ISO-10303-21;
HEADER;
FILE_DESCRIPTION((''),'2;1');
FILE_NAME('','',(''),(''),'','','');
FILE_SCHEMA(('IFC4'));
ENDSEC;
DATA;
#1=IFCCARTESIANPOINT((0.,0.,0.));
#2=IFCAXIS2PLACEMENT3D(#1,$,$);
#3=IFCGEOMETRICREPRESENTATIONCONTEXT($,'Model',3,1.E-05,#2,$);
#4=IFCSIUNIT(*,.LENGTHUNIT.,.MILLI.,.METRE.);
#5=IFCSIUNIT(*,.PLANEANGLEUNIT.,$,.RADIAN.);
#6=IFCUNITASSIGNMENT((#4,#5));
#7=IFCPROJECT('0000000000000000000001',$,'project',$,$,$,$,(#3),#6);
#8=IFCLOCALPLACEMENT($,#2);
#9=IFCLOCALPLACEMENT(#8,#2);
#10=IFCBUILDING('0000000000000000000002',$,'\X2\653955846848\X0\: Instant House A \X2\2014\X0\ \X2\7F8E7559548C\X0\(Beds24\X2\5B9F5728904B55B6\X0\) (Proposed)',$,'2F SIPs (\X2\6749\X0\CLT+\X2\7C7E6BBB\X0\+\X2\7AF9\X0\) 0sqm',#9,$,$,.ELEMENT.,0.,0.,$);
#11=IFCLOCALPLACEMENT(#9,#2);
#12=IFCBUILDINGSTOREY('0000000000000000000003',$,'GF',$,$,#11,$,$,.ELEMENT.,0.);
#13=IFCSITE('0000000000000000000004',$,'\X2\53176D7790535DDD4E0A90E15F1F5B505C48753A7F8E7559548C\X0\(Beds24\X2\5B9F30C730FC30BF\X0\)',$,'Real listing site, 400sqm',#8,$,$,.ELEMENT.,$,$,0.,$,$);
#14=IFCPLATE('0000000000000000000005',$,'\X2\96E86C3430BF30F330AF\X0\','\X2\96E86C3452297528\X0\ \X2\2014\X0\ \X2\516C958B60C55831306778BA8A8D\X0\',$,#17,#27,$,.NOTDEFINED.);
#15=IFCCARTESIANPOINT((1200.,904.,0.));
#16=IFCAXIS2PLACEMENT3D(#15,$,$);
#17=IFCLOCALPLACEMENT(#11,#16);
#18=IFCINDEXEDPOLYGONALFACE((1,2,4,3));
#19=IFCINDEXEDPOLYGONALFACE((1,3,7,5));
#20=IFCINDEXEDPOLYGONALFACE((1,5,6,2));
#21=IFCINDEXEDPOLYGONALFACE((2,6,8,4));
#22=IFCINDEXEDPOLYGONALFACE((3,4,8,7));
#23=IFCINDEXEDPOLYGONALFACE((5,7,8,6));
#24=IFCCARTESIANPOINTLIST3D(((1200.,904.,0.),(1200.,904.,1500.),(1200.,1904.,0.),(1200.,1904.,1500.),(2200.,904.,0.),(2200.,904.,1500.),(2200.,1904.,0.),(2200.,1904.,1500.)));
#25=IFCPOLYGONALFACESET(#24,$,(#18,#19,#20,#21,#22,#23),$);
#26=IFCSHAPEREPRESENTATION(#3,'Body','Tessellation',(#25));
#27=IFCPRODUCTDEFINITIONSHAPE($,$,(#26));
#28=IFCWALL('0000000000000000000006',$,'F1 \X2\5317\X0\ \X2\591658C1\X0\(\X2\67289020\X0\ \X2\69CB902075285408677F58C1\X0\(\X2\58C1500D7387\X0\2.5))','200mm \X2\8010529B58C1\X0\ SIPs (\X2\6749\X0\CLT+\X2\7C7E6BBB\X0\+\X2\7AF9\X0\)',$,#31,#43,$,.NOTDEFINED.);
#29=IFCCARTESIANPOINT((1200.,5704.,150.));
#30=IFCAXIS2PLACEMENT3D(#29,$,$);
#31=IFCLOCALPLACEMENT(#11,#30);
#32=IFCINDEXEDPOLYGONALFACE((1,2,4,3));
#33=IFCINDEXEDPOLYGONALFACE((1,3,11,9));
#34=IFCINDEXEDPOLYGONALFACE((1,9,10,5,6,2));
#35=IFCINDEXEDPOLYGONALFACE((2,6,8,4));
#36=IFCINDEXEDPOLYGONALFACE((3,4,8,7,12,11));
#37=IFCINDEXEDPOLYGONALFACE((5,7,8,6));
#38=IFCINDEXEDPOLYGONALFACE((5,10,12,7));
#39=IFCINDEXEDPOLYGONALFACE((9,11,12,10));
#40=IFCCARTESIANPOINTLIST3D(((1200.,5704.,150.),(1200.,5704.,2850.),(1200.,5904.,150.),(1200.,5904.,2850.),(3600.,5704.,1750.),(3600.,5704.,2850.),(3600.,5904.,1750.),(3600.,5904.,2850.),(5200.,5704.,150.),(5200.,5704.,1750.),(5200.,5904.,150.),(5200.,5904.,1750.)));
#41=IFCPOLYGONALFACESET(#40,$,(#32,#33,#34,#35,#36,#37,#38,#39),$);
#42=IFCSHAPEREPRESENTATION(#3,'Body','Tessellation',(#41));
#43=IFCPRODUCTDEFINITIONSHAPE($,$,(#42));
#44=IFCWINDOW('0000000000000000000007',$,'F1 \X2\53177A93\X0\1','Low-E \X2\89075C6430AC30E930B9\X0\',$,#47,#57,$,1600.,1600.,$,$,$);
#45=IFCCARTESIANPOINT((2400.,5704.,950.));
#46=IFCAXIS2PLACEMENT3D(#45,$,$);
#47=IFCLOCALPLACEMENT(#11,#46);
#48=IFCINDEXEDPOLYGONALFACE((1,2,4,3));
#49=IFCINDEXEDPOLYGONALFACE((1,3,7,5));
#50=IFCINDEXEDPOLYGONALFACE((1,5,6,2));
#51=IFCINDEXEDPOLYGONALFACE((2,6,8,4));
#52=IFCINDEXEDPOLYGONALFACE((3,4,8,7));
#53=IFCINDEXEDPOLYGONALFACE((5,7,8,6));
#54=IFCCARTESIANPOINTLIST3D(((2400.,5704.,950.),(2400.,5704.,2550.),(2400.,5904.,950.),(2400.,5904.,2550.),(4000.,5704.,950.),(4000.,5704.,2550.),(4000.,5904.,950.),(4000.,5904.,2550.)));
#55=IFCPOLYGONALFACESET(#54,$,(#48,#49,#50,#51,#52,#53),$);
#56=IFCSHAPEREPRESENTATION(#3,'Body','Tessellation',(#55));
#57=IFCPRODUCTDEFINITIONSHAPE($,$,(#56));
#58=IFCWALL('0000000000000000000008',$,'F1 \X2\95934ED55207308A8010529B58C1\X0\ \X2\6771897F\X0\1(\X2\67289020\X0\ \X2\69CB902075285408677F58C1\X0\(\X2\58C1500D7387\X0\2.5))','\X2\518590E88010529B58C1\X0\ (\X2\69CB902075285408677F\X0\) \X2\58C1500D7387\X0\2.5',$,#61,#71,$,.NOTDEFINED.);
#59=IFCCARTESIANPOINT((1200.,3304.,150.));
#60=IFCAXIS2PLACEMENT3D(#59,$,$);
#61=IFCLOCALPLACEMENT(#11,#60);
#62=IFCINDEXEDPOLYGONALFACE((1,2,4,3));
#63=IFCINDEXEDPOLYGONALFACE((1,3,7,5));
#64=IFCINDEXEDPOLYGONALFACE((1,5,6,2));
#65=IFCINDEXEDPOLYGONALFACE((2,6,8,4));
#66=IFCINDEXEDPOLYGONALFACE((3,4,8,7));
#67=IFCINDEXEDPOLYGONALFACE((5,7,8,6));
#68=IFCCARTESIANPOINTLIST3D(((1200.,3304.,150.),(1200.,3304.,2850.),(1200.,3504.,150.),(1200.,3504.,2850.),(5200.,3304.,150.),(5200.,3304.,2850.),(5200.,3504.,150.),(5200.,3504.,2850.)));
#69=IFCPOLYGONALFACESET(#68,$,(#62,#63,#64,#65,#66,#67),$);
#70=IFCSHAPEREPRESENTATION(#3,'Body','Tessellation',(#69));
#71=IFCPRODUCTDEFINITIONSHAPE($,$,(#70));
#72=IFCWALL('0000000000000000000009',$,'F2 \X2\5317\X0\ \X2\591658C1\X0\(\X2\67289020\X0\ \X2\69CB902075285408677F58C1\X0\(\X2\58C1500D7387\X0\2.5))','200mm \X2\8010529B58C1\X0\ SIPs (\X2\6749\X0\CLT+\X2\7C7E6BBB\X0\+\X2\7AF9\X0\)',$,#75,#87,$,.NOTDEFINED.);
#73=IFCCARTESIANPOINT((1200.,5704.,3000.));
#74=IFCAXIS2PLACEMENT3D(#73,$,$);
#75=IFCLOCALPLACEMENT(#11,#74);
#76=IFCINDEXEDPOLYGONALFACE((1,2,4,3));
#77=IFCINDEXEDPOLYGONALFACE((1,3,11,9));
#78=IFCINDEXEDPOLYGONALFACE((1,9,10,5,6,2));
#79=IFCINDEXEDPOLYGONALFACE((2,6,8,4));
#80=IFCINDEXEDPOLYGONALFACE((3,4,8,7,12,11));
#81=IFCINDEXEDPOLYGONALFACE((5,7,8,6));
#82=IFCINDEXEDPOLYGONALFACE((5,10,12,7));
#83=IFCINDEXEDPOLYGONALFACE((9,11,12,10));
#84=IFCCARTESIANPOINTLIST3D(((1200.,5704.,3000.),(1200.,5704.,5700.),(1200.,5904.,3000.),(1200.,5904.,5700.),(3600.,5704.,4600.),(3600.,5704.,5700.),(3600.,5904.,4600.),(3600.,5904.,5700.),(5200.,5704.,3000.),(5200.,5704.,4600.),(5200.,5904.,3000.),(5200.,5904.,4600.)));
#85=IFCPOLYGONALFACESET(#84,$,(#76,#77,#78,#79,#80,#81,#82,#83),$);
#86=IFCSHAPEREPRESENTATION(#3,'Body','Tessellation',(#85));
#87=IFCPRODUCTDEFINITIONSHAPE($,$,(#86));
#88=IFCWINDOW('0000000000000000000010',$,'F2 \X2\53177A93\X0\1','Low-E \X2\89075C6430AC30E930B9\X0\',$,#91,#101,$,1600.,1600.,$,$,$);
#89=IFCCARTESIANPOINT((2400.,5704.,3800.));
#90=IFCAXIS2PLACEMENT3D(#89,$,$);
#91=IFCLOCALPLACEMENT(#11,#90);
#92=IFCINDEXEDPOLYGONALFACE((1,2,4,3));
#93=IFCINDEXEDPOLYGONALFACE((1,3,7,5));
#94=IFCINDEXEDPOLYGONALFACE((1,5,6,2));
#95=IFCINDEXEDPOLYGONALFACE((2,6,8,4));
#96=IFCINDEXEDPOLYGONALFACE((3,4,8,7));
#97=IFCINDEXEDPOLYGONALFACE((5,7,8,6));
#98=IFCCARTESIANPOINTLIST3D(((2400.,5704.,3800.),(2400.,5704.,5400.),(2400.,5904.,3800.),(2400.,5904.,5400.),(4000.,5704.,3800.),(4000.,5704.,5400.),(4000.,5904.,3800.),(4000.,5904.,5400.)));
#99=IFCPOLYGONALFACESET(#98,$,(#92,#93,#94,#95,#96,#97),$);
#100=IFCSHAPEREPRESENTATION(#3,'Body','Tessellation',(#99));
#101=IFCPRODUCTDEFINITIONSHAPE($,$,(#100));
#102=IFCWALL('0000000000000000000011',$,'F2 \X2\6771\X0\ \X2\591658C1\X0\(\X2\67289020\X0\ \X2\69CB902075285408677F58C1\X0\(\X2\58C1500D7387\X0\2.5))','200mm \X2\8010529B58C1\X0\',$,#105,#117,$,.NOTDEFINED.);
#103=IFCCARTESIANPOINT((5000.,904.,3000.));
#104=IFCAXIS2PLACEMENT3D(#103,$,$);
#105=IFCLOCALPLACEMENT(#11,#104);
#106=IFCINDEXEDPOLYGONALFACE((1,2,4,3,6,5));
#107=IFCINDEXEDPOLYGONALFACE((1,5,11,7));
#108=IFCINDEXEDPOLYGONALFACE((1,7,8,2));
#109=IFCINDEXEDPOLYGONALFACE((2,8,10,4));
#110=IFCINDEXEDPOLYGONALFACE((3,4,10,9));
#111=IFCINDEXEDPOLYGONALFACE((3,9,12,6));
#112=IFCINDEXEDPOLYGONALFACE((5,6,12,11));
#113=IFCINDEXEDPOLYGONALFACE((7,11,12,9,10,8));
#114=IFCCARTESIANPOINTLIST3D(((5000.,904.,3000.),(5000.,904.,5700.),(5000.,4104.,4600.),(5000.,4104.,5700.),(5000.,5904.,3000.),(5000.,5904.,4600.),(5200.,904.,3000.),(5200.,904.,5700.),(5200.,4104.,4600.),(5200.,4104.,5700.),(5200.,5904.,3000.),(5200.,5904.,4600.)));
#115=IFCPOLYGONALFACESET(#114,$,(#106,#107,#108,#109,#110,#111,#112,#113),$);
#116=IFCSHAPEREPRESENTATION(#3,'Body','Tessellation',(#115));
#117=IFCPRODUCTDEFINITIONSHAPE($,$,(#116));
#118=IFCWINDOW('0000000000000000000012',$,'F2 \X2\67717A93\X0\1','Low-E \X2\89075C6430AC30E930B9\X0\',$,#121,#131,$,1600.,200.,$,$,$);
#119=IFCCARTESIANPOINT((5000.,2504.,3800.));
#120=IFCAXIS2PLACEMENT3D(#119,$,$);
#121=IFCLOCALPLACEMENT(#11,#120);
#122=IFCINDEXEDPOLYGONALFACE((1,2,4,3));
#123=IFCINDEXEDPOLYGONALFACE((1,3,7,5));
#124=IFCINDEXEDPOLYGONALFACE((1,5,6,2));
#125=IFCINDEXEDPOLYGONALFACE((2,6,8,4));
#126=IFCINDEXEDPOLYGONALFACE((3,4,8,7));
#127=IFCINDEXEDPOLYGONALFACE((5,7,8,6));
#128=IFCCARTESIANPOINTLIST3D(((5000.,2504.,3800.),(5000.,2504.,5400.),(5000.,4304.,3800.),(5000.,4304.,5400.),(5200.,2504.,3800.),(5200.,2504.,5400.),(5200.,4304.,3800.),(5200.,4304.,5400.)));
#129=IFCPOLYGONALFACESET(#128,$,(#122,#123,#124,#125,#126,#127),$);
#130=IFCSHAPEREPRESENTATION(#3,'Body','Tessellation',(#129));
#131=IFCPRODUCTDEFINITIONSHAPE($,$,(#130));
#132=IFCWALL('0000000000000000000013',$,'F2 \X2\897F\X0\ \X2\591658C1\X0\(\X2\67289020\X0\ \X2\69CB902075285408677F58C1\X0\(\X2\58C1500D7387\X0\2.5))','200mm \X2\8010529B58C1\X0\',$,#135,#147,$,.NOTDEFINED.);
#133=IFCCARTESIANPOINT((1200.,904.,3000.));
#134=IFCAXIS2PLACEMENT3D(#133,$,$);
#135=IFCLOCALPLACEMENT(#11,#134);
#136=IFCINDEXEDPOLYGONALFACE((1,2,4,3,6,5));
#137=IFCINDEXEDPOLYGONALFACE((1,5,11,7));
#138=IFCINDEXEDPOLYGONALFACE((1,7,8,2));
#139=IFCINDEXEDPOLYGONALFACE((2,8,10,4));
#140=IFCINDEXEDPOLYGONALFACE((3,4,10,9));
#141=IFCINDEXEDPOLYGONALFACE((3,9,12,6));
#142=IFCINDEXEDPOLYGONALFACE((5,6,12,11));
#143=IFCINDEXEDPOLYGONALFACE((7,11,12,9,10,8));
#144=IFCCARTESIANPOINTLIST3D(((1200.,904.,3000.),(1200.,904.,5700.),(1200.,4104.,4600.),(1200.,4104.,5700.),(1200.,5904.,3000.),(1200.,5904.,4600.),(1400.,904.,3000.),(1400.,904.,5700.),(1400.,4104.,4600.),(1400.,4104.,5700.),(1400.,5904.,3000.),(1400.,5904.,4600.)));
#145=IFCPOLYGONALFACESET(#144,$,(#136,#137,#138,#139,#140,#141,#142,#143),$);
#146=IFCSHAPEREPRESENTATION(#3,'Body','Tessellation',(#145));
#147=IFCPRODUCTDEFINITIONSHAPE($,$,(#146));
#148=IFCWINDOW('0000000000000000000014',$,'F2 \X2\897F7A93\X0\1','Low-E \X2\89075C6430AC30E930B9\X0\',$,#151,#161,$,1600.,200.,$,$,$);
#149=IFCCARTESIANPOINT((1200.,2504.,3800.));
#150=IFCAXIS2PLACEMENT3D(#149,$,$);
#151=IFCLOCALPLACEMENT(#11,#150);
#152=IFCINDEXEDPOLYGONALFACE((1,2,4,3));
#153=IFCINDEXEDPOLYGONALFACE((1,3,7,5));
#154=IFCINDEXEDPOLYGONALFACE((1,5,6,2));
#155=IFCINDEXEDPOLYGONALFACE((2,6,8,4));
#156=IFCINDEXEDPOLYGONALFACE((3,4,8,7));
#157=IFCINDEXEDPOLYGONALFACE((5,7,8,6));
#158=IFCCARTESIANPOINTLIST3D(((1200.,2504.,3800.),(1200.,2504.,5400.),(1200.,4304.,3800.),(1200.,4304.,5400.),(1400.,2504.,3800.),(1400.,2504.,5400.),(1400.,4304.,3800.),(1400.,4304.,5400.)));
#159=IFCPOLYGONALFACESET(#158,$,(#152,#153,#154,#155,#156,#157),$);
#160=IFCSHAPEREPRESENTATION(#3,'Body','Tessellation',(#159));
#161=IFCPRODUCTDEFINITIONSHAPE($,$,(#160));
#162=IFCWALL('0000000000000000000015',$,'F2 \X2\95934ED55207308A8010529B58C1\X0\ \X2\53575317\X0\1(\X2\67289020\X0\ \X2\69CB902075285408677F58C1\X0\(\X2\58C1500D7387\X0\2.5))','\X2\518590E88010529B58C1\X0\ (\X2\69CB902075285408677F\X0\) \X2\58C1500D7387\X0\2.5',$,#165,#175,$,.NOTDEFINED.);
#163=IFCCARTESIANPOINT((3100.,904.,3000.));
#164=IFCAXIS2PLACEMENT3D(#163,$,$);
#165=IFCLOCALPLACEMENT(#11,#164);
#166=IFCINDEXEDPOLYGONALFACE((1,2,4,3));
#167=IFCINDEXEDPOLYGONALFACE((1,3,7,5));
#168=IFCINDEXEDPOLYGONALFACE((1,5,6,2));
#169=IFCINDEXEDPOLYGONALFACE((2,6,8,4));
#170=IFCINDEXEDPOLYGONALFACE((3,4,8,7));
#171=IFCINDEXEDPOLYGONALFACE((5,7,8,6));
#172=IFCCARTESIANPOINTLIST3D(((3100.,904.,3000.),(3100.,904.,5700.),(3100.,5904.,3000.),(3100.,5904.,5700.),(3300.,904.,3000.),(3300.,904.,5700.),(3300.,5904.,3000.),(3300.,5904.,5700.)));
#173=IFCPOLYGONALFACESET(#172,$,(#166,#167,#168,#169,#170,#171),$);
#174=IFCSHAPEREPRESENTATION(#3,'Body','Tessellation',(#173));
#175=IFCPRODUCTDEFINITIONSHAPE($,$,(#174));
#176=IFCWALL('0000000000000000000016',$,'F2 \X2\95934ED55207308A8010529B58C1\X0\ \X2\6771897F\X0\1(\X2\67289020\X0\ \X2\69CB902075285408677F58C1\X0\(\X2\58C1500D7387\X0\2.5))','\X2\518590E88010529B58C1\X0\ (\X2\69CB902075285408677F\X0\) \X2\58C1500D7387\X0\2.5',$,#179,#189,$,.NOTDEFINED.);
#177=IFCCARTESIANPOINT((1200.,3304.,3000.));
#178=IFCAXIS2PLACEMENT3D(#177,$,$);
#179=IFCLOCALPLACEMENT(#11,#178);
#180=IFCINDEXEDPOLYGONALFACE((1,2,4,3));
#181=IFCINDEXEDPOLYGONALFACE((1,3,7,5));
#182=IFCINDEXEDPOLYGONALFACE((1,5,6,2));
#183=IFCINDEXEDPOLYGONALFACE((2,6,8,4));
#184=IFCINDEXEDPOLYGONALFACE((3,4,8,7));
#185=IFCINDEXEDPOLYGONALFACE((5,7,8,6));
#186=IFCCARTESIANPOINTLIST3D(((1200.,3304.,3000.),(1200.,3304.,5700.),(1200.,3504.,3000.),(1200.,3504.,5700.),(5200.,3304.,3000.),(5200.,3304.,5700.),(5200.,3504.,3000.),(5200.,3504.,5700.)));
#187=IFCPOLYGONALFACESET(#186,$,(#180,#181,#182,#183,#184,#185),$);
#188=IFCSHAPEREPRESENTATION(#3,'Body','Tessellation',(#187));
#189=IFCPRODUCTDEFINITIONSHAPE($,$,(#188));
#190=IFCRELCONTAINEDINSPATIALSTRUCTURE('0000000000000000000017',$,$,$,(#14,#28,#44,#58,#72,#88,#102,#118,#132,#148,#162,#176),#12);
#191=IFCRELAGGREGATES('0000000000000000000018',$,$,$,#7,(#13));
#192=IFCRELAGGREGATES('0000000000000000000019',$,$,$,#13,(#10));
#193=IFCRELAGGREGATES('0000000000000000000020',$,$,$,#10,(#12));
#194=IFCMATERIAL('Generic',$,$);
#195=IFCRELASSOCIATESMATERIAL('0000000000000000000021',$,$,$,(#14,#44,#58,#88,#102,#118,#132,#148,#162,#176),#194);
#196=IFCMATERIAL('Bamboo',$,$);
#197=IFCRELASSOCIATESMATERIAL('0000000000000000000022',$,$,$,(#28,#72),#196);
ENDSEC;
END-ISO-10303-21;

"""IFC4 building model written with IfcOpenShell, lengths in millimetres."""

from ifc_helpers import new_model, si_unit, frame, frame_2d, origin, place, context, project, spatial, rectangle, extrude, material, element, fill, save


model = new_model("IFC4")

# Units and contexts
model_context = context("Model", 3, precision=1e-05, world=origin())
ifc_project = project(units=[si_unit("LENGTHUNIT", "METRE", prefix="MILLI"), si_unit("PLANEANGLEUNIT", "RADIAN")], contexts=[model_context])

# Site, building, storey
site_placement = place(None, origin())
site = spatial("IfcSite", under=ifc_project, at=site_placement, Name="北海道川上郡弟子屈町美留和(Beds24実データ)", ObjectType="Real listing site, 400sqm", CompositionType="ELEMENT", RefElevation=0.0)
building_placement = place(site_placement, origin())
building = spatial("IfcBuilding", under=site, at=building_placement, Name="改善案: Instant House A — 美留和(Beds24実在運営) (Proposed)", ObjectType="2F SIPs (杉CLT+籾殻+竹) 0sqm", CompositionType="ELEMENT", ElevationOfRefHeight=0.0, ElevationOfTerrain=0.0)
storey_placement = place(building_placement, origin())
storey = spatial("IfcBuildingStorey", under=building, at=storey_placement, Name="GF", CompositionType="ELEMENT", Elevation=0.0)

# Plate
ifc_material_1 = material(Name="Generic")
plate_placement = place(storey_placement, frame((1200.0, 904.0, 0.0)))
element("IfcPlate", 1, at=plate_placement, inside=storey, material=ifc_material_1, Name="雨水タンク", Description="雨水利用 — 公開情報で確認", PredefinedType="NOTDEFINED", context=model_context, shape_type="SweptSolid", body=[
    extrude(rectangle(XDim=1000.0, YDim=1000.0, at=frame_2d((500.0, 500.0))), frame((1200.0, 904.0, 0.0)), (0.0, 0.0, 1.0), 1500.0),
])

# Wall, opening, window
ifc_material_2 = material(Name="Bamboo")
wall_1_placement = place(storey_placement, frame((1200.0, 5704.0, 150.0)))
wall_1 = element("IfcWall", 2, at=wall_1_placement, inside=storey, material=ifc_material_2, Name="F1 北 外壁(木造 構造用合板壁(壁倍率2.5))", Description="200mm 耐力壁 SIPs (杉CLT+籾殻+竹)", PredefinedType="NOTDEFINED", context=model_context, shape_type="SweptSolid", body=[
    extrude(rectangle(XDim=4000.0, YDim=200.0, at=frame_2d((2000.0, 100.0))), frame((1200.0, 5704.0, 150.0)), (0.0, 0.0, 1.0), 2700.0),
])
opening_1_placement = place(storey_placement, frame((2400.0, 5704.0, 950.0)))
opening_1 = element("IfcOpeningElement", 3, at=opening_1_placement, cuts=wall_1, PredefinedType="NOTDEFINED", context=model_context, shape_type="SweptSolid", body=[
    extrude(rectangle(XDim=1600.0, YDim=200.0, at=frame_2d((800.0, 100.0))), frame((2400.0, 5704.0, 950.0)), (0.0, 0.0, 1.0), 1600.0),
])
window_1_placement = place(storey_placement, frame((2400.0, 5704.0, 950.0)))
window_1 = element("IfcWindow", 4, at=window_1_placement, inside=storey, material=ifc_material_1, Name="F1 北窓1", Description="Low-E 複層ガラス", OverallHeight=1600.0, OverallWidth=1600.0, context=model_context, shape_type="SweptSolid", body=[
    extrude(rectangle(XDim=1600.0, YDim=200.0, at=frame_2d((800.0, 100.0))), frame((2400.0, 5704.0, 950.0)), (0.0, 0.0, 1.0), 1600.0),
])
fill(opening_1, window_1)

# Wall
wall_2_placement = place(storey_placement, frame((1200.0, 3304.0, 150.0)))
element("IfcWall", 5, at=wall_2_placement, inside=storey, material=ifc_material_1, Name="F1 間仕切り耐力壁 東西1(木造 構造用合板壁(壁倍率2.5))", Description="内部耐力壁 (構造用合板) 壁倍率2.5", PredefinedType="NOTDEFINED", context=model_context, shape_type="SweptSolid", body=[
    extrude(rectangle(XDim=4000.0, YDim=200.0, at=frame_2d((2000.0, 100.0))), frame((1200.0, 3304.0, 150.0)), (0.0, 0.0, 1.0), 2700.0),
])

# Walls, openings, windows
wall_3_placement = place(storey_placement, frame((1200.0, 5704.0, 3000.0)))
wall_3 = element("IfcWall", 6, at=wall_3_placement, inside=storey, material=ifc_material_2, Name="F2 北 外壁(木造 構造用合板壁(壁倍率2.5))", Description="200mm 耐力壁 SIPs (杉CLT+籾殻+竹)", PredefinedType="NOTDEFINED", context=model_context, shape_type="SweptSolid", body=[
    extrude(rectangle(XDim=4000.0, YDim=200.0, at=frame_2d((2000.0, 100.0))), frame((1200.0, 5704.0, 3000.0)), (0.0, 0.0, 1.0), 2700.0),
])
opening_2_placement = place(storey_placement, frame((2400.0, 5704.0, 3800.0)))
opening_2 = element("IfcOpeningElement", 7, at=opening_2_placement, cuts=wall_3, PredefinedType="NOTDEFINED", context=model_context, shape_type="SweptSolid", body=[
    extrude(rectangle(XDim=1600.0, YDim=200.0, at=frame_2d((800.0, 100.0))), frame((2400.0, 5704.0, 3800.0)), (0.0, 0.0, 1.0), 1600.0),
])
window_2_placement = place(storey_placement, frame((2400.0, 5704.0, 3800.0)))
window_2 = element("IfcWindow", 8, at=window_2_placement, inside=storey, material=ifc_material_1, Name="F2 北窓1", Description="Low-E 複層ガラス", OverallHeight=1600.0, OverallWidth=1600.0, context=model_context, shape_type="SweptSolid", body=[
    extrude(rectangle(XDim=1600.0, YDim=200.0, at=frame_2d((800.0, 100.0))), frame((2400.0, 5704.0, 3800.0)), (0.0, 0.0, 1.0), 1600.0),
])
fill(opening_2, window_2)
wall_4_placement = place(storey_placement, frame((5000.0, 904.0, 3000.0)))
wall_4 = element("IfcWall", 9, at=wall_4_placement, inside=storey, material=ifc_material_1, Name="F2 東 外壁(木造 構造用合板壁(壁倍率2.5))", Description="200mm 耐力壁", PredefinedType="NOTDEFINED", context=model_context, shape_type="SweptSolid", body=[
    extrude(rectangle(XDim=200.0, YDim=5000.0, at=frame_2d((100.0, 2500.0))), frame((5000.0, 904.0, 3000.0)), (0.0, 0.0, 1.0), 2700.0),
])
opening_3_placement = place(storey_placement, frame((5000.0, 2504.0, 3800.0)))
opening_3 = element("IfcOpeningElement", 10, at=opening_3_placement, cuts=wall_4, PredefinedType="NOTDEFINED", context=model_context, shape_type="SweptSolid", body=[
    extrude(rectangle(XDim=200.0, YDim=1800.0, at=frame_2d((100.0, 900.0))), frame((5000.0, 2504.0, 3800.0)), (0.0, 0.0, 1.0), 1600.0),
])
window_3_placement = place(storey_placement, frame((5000.0, 2504.0, 3800.0)))
window_3 = element("IfcWindow", 11, at=window_3_placement, inside=storey, material=ifc_material_1, Name="F2 東窓1", Description="Low-E 複層ガラス", OverallHeight=1600.0, OverallWidth=200.0, context=model_context, shape_type="SweptSolid", body=[
    extrude(rectangle(XDim=200.0, YDim=1800.0, at=frame_2d((100.0, 900.0))), frame((5000.0, 2504.0, 3800.0)), (0.0, 0.0, 1.0), 1600.0),
])
fill(opening_3, window_3)
wall_5_placement = place(storey_placement, frame((1200.0, 904.0, 3000.0)))
wall_5 = element("IfcWall", 12, at=wall_5_placement, inside=storey, material=ifc_material_1, Name="F2 西 外壁(木造 構造用合板壁(壁倍率2.5))", Description="200mm 耐力壁", PredefinedType="NOTDEFINED", context=model_context, shape_type="SweptSolid", body=[
    extrude(rectangle(XDim=200.0, YDim=5000.0, at=frame_2d((100.0, 2500.0))), frame((1200.0, 904.0, 3000.0)), (0.0, 0.0, 1.0), 2700.0),
])
opening_4_placement = place(storey_placement, frame((1200.0, 2504.0, 3800.0)))
opening_4 = element("IfcOpeningElement", 13, at=opening_4_placement, cuts=wall_5, PredefinedType="NOTDEFINED", context=model_context, shape_type="SweptSolid", body=[
    extrude(rectangle(XDim=200.0, YDim=1800.0, at=frame_2d((100.0, 900.0))), frame((1200.0, 2504.0, 3800.0)), (0.0, 0.0, 1.0), 1600.0),
])
window_4_placement = place(storey_placement, frame((1200.0, 2504.0, 3800.0)))
window_4 = element("IfcWindow", 14, at=window_4_placement, inside=storey, material=ifc_material_1, Name="F2 西窓1", Description="Low-E 複層ガラス", OverallHeight=1600.0, OverallWidth=200.0, context=model_context, shape_type="SweptSolid", body=[
    extrude(rectangle(XDim=200.0, YDim=1800.0, at=frame_2d((100.0, 900.0))), frame((1200.0, 2504.0, 3800.0)), (0.0, 0.0, 1.0), 1600.0),
])
fill(opening_4, window_4)

# Walls
wall_6_placement = place(storey_placement, frame((3100.0, 904.0, 3000.0)))
element("IfcWall", 15, at=wall_6_placement, inside=storey, material=ifc_material_1, Name="F2 間仕切り耐力壁 南北1(木造 構造用合板壁(壁倍率2.5))", Description="内部耐力壁 (構造用合板) 壁倍率2.5", PredefinedType="NOTDEFINED", context=model_context, shape_type="SweptSolid", body=[
    extrude(rectangle(XDim=200.0, YDim=5000.0, at=frame_2d((100.0, 2500.0))), frame((3100.0, 904.0, 3000.0)), (0.0, 0.0, 1.0), 2700.0),
])
wall_7_placement = place(storey_placement, frame((1200.0, 3304.0, 3000.0)))
element("IfcWall", 16, at=wall_7_placement, inside=storey, material=ifc_material_1, Name="F2 間仕切り耐力壁 東西1(木造 構造用合板壁(壁倍率2.5))", Description="内部耐力壁 (構造用合板) 壁倍率2.5", PredefinedType="NOTDEFINED", context=model_context, shape_type="SweptSolid", body=[
    extrude(rectangle(XDim=4000.0, YDim=200.0, at=frame_2d((2000.0, 100.0))), frame((1200.0, 3304.0, 3000.0)), (0.0, 0.0, 1.0), 2700.0),
])

save(model, "model.ifc")
